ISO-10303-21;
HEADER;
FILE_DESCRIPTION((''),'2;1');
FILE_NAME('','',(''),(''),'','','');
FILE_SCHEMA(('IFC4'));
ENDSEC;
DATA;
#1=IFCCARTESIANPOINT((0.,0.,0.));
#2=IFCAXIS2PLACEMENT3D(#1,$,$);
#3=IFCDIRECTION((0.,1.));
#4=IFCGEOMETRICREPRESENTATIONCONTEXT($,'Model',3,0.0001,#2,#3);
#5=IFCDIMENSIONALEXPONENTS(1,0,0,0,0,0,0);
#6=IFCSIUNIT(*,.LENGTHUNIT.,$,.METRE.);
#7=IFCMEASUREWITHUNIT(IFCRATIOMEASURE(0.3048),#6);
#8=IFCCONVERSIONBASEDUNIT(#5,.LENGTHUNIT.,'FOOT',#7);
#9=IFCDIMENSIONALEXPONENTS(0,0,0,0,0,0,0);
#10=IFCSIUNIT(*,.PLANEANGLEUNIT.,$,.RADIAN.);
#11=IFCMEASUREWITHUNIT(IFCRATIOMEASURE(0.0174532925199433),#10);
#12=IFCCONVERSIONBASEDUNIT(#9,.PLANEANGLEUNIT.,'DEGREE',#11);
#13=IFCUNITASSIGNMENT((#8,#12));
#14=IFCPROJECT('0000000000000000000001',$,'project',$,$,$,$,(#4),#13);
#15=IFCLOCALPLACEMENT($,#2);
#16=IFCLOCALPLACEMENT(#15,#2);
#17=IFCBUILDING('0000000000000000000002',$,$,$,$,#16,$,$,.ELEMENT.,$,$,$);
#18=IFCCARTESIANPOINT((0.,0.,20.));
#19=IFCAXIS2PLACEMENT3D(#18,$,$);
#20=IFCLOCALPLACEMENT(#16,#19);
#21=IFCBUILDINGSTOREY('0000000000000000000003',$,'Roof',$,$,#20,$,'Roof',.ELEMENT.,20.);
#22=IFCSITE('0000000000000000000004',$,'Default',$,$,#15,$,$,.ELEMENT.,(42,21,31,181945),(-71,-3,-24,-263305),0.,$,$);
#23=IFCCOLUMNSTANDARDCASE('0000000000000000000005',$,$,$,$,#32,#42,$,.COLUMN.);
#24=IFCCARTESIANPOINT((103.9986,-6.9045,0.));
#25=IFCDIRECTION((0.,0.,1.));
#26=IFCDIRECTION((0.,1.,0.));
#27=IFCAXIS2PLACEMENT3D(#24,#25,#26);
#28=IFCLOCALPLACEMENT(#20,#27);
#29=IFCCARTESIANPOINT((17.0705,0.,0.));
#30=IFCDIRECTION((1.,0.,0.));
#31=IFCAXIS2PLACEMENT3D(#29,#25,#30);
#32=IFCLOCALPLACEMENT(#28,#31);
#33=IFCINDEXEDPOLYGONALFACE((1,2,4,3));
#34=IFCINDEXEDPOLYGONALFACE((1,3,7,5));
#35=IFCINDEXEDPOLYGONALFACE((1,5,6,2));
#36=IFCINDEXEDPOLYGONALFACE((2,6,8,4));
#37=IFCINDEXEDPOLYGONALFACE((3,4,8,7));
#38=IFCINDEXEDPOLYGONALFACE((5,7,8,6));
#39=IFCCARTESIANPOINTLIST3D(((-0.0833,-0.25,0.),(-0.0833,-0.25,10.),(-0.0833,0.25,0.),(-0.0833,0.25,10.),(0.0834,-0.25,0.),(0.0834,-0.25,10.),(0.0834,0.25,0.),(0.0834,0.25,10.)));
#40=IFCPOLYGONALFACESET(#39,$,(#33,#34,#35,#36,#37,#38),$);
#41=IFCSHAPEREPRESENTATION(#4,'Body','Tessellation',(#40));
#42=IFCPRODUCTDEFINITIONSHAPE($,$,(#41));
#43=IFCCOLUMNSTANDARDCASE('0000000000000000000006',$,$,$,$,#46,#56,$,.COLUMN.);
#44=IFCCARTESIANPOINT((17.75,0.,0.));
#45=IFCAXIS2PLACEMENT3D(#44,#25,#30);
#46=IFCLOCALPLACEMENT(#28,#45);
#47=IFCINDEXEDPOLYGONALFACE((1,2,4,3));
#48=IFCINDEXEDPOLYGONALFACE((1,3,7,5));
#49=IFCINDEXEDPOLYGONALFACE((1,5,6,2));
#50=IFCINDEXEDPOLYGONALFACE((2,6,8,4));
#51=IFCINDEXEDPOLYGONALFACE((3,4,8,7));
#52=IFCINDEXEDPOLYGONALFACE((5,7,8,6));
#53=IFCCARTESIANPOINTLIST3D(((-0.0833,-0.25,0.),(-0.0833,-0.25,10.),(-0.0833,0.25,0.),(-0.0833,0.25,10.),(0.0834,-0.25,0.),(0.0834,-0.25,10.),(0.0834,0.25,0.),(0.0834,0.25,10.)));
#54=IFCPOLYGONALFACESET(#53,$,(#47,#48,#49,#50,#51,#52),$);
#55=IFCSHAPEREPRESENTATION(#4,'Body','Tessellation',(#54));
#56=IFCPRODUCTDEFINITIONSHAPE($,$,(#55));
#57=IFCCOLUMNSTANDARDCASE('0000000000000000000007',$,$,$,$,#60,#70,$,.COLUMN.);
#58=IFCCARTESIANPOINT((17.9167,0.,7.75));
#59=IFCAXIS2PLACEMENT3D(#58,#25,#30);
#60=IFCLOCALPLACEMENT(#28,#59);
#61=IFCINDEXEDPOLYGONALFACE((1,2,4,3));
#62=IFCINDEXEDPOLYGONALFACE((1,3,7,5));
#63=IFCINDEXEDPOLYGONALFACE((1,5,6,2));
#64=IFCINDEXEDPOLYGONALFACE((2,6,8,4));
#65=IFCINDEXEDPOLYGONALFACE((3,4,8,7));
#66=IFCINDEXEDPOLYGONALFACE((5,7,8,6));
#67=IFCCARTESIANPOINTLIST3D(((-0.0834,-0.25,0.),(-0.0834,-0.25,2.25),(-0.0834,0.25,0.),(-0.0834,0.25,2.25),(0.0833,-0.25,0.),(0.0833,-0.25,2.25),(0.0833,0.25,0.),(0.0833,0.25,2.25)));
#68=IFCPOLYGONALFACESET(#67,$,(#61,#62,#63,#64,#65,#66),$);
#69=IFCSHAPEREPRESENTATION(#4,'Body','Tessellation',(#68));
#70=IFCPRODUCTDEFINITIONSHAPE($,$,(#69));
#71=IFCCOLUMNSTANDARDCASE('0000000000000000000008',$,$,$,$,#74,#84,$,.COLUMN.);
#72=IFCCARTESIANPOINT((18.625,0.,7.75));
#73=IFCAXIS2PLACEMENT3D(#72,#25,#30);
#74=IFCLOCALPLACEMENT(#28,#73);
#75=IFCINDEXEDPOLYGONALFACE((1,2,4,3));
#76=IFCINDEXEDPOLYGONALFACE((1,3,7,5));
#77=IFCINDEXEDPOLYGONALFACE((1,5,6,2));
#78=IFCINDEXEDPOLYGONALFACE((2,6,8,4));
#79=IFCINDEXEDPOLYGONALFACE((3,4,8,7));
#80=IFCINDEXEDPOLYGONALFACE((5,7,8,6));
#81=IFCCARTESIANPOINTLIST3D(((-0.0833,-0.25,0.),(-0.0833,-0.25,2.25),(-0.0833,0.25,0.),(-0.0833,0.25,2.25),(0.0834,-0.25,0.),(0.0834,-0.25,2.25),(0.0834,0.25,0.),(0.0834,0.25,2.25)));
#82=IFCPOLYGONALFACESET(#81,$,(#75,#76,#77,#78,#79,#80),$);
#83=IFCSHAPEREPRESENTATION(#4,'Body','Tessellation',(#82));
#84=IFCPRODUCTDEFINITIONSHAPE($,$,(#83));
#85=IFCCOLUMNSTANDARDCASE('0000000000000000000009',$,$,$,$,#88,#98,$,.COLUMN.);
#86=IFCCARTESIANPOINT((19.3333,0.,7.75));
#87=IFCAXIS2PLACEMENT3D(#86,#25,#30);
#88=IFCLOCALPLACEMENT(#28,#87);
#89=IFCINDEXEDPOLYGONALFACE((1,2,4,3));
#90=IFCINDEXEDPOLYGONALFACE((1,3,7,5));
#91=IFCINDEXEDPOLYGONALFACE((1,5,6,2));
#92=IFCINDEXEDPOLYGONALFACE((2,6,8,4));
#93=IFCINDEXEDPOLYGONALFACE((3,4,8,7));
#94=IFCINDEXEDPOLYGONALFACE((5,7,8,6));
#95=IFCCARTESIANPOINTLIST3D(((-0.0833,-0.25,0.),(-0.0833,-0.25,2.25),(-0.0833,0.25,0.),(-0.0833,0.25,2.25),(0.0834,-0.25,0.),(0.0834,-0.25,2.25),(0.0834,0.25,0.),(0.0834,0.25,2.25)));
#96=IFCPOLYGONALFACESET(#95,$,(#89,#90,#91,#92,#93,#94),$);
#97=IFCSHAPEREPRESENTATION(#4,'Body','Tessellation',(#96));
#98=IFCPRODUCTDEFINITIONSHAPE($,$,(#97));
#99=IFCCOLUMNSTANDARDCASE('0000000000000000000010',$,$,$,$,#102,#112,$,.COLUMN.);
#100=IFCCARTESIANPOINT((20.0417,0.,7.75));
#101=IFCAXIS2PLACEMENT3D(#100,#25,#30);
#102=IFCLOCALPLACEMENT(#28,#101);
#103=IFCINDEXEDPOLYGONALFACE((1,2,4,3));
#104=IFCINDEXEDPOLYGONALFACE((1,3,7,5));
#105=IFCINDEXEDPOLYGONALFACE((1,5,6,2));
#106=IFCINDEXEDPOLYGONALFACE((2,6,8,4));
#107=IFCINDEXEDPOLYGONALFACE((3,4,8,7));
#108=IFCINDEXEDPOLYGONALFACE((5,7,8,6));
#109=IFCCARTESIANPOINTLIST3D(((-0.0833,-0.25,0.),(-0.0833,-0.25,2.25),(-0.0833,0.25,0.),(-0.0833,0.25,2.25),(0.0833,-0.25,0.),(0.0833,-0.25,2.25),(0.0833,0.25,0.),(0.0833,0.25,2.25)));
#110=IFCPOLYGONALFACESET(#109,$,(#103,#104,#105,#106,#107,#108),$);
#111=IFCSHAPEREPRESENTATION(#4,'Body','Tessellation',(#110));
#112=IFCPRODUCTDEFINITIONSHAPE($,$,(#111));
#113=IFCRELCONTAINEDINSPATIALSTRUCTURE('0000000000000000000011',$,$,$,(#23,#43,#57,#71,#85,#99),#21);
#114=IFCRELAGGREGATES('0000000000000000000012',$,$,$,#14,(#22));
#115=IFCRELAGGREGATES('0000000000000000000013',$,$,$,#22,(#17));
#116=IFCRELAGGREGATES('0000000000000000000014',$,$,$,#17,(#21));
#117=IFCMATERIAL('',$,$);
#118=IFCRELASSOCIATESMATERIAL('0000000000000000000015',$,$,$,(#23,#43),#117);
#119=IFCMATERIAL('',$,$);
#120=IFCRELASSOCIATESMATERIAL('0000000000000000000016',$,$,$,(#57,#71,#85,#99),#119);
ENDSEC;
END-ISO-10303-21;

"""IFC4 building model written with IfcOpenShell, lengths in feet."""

from ifc_helpers import new_model, entity, si_unit, converted_unit, direction, frame, origin, place, context, project, spatial, rectangle, extrude, material, element, save


model = new_model("IFC4")

# Units and contexts
model_context = context("Model", 3, precision=0.0001, world=origin(), true_north=direction((0.0, 1.0)))
ifc_project = project(units=[converted_unit("LENGTHUNIT", "FOOT", entity("IfcRatioMeasure", 0.3048), si_unit("LENGTHUNIT", "METRE"), dimensions=[1, 0, 0, 0, 0, 0, 0]), converted_unit("PLANEANGLEUNIT", "DEGREE", entity("IfcRatioMeasure", 0.0174532925199433), si_unit("PLANEANGLEUNIT", "RADIAN"), dimensions=[0, 0, 0, 0, 0, 0, 0])], contexts=[model_context])

# Site, building, storey
site_placement = place(None, origin())
site = spatial("IfcSite", under=ifc_project, at=site_placement, Name="Default", CompositionType="ELEMENT", RefLatitude=(42, 21, 31, 181945), RefLongitude=(-71, -3, -24, -263305), RefElevation=0.0)
building_placement = place(site_placement, origin())
building = spatial("IfcBuilding", under=site, at=building_placement, CompositionType="ELEMENT")
storey_placement = place(building_placement, frame((0.0, 0.0, 20.0)))
storey = spatial("IfcBuildingStorey", under=building, at=storey_placement, Name="Roof", LongName="Roof", CompositionType="ELEMENT", Elevation=20.0)

# Columns
ifc_material_1 = material(Name="")
placement = place(storey_placement, frame((103.9986, -6.9045, 0.0), z_axis=(0.0, 0.0, 1.0), x_axis=(0.0, 1.0, 0.0)))
for number, where, z_axis, x_axis in (
    (1, (17.0705, 0.0, 0.0), (0.0, 0.0, 1.0), (1.0, 0.0, 0.0)),
    (2, (17.75, 0.0, 0.0), (0.0, 0.0, 1.0), (1.0, 0.0, 0.0)),
):
    element("IfcColumnStandardCase", number, at=place(placement, frame(where, z_axis=z_axis, x_axis=x_axis)), inside=storey, material=ifc_material_1, PredefinedType="COLUMN", context=model_context, shape_type="SweptSolid", body=[
        extrude(rectangle(XDim=0.1667, YDim=0.5), origin(), (0.0, 0.0, 1.0), 10.0),
    ])
ifc_material_2 = material(Name="")
for number, where, z_axis, x_axis in (
    (3, (17.9167, 0.0, 7.75), (0.0, 0.0, 1.0), (1.0, 0.0, 0.0)),
    (4, (18.625, 0.0, 7.75), (0.0, 0.0, 1.0), (1.0, 0.0, 0.0)),
    (5, (19.3333, 0.0, 7.75), (0.0, 0.0, 1.0), (1.0, 0.0, 0.0)),
    (6, (20.0417, 0.0, 7.75), (0.0, 0.0, 1.0), (1.0, 0.0, 0.0)),
):
    element("IfcColumnStandardCase", number, at=place(placement, frame(where, z_axis=z_axis, x_axis=x_axis)), inside=storey, material=ifc_material_2, PredefinedType="COLUMN", context=model_context, shape_type="SweptSolid", body=[
        extrude(rectangle(XDim=0.1667, YDim=0.5), origin(), (0.0, 0.0, 1.0), 2.25),
    ])

save(model, "model.ifc")
